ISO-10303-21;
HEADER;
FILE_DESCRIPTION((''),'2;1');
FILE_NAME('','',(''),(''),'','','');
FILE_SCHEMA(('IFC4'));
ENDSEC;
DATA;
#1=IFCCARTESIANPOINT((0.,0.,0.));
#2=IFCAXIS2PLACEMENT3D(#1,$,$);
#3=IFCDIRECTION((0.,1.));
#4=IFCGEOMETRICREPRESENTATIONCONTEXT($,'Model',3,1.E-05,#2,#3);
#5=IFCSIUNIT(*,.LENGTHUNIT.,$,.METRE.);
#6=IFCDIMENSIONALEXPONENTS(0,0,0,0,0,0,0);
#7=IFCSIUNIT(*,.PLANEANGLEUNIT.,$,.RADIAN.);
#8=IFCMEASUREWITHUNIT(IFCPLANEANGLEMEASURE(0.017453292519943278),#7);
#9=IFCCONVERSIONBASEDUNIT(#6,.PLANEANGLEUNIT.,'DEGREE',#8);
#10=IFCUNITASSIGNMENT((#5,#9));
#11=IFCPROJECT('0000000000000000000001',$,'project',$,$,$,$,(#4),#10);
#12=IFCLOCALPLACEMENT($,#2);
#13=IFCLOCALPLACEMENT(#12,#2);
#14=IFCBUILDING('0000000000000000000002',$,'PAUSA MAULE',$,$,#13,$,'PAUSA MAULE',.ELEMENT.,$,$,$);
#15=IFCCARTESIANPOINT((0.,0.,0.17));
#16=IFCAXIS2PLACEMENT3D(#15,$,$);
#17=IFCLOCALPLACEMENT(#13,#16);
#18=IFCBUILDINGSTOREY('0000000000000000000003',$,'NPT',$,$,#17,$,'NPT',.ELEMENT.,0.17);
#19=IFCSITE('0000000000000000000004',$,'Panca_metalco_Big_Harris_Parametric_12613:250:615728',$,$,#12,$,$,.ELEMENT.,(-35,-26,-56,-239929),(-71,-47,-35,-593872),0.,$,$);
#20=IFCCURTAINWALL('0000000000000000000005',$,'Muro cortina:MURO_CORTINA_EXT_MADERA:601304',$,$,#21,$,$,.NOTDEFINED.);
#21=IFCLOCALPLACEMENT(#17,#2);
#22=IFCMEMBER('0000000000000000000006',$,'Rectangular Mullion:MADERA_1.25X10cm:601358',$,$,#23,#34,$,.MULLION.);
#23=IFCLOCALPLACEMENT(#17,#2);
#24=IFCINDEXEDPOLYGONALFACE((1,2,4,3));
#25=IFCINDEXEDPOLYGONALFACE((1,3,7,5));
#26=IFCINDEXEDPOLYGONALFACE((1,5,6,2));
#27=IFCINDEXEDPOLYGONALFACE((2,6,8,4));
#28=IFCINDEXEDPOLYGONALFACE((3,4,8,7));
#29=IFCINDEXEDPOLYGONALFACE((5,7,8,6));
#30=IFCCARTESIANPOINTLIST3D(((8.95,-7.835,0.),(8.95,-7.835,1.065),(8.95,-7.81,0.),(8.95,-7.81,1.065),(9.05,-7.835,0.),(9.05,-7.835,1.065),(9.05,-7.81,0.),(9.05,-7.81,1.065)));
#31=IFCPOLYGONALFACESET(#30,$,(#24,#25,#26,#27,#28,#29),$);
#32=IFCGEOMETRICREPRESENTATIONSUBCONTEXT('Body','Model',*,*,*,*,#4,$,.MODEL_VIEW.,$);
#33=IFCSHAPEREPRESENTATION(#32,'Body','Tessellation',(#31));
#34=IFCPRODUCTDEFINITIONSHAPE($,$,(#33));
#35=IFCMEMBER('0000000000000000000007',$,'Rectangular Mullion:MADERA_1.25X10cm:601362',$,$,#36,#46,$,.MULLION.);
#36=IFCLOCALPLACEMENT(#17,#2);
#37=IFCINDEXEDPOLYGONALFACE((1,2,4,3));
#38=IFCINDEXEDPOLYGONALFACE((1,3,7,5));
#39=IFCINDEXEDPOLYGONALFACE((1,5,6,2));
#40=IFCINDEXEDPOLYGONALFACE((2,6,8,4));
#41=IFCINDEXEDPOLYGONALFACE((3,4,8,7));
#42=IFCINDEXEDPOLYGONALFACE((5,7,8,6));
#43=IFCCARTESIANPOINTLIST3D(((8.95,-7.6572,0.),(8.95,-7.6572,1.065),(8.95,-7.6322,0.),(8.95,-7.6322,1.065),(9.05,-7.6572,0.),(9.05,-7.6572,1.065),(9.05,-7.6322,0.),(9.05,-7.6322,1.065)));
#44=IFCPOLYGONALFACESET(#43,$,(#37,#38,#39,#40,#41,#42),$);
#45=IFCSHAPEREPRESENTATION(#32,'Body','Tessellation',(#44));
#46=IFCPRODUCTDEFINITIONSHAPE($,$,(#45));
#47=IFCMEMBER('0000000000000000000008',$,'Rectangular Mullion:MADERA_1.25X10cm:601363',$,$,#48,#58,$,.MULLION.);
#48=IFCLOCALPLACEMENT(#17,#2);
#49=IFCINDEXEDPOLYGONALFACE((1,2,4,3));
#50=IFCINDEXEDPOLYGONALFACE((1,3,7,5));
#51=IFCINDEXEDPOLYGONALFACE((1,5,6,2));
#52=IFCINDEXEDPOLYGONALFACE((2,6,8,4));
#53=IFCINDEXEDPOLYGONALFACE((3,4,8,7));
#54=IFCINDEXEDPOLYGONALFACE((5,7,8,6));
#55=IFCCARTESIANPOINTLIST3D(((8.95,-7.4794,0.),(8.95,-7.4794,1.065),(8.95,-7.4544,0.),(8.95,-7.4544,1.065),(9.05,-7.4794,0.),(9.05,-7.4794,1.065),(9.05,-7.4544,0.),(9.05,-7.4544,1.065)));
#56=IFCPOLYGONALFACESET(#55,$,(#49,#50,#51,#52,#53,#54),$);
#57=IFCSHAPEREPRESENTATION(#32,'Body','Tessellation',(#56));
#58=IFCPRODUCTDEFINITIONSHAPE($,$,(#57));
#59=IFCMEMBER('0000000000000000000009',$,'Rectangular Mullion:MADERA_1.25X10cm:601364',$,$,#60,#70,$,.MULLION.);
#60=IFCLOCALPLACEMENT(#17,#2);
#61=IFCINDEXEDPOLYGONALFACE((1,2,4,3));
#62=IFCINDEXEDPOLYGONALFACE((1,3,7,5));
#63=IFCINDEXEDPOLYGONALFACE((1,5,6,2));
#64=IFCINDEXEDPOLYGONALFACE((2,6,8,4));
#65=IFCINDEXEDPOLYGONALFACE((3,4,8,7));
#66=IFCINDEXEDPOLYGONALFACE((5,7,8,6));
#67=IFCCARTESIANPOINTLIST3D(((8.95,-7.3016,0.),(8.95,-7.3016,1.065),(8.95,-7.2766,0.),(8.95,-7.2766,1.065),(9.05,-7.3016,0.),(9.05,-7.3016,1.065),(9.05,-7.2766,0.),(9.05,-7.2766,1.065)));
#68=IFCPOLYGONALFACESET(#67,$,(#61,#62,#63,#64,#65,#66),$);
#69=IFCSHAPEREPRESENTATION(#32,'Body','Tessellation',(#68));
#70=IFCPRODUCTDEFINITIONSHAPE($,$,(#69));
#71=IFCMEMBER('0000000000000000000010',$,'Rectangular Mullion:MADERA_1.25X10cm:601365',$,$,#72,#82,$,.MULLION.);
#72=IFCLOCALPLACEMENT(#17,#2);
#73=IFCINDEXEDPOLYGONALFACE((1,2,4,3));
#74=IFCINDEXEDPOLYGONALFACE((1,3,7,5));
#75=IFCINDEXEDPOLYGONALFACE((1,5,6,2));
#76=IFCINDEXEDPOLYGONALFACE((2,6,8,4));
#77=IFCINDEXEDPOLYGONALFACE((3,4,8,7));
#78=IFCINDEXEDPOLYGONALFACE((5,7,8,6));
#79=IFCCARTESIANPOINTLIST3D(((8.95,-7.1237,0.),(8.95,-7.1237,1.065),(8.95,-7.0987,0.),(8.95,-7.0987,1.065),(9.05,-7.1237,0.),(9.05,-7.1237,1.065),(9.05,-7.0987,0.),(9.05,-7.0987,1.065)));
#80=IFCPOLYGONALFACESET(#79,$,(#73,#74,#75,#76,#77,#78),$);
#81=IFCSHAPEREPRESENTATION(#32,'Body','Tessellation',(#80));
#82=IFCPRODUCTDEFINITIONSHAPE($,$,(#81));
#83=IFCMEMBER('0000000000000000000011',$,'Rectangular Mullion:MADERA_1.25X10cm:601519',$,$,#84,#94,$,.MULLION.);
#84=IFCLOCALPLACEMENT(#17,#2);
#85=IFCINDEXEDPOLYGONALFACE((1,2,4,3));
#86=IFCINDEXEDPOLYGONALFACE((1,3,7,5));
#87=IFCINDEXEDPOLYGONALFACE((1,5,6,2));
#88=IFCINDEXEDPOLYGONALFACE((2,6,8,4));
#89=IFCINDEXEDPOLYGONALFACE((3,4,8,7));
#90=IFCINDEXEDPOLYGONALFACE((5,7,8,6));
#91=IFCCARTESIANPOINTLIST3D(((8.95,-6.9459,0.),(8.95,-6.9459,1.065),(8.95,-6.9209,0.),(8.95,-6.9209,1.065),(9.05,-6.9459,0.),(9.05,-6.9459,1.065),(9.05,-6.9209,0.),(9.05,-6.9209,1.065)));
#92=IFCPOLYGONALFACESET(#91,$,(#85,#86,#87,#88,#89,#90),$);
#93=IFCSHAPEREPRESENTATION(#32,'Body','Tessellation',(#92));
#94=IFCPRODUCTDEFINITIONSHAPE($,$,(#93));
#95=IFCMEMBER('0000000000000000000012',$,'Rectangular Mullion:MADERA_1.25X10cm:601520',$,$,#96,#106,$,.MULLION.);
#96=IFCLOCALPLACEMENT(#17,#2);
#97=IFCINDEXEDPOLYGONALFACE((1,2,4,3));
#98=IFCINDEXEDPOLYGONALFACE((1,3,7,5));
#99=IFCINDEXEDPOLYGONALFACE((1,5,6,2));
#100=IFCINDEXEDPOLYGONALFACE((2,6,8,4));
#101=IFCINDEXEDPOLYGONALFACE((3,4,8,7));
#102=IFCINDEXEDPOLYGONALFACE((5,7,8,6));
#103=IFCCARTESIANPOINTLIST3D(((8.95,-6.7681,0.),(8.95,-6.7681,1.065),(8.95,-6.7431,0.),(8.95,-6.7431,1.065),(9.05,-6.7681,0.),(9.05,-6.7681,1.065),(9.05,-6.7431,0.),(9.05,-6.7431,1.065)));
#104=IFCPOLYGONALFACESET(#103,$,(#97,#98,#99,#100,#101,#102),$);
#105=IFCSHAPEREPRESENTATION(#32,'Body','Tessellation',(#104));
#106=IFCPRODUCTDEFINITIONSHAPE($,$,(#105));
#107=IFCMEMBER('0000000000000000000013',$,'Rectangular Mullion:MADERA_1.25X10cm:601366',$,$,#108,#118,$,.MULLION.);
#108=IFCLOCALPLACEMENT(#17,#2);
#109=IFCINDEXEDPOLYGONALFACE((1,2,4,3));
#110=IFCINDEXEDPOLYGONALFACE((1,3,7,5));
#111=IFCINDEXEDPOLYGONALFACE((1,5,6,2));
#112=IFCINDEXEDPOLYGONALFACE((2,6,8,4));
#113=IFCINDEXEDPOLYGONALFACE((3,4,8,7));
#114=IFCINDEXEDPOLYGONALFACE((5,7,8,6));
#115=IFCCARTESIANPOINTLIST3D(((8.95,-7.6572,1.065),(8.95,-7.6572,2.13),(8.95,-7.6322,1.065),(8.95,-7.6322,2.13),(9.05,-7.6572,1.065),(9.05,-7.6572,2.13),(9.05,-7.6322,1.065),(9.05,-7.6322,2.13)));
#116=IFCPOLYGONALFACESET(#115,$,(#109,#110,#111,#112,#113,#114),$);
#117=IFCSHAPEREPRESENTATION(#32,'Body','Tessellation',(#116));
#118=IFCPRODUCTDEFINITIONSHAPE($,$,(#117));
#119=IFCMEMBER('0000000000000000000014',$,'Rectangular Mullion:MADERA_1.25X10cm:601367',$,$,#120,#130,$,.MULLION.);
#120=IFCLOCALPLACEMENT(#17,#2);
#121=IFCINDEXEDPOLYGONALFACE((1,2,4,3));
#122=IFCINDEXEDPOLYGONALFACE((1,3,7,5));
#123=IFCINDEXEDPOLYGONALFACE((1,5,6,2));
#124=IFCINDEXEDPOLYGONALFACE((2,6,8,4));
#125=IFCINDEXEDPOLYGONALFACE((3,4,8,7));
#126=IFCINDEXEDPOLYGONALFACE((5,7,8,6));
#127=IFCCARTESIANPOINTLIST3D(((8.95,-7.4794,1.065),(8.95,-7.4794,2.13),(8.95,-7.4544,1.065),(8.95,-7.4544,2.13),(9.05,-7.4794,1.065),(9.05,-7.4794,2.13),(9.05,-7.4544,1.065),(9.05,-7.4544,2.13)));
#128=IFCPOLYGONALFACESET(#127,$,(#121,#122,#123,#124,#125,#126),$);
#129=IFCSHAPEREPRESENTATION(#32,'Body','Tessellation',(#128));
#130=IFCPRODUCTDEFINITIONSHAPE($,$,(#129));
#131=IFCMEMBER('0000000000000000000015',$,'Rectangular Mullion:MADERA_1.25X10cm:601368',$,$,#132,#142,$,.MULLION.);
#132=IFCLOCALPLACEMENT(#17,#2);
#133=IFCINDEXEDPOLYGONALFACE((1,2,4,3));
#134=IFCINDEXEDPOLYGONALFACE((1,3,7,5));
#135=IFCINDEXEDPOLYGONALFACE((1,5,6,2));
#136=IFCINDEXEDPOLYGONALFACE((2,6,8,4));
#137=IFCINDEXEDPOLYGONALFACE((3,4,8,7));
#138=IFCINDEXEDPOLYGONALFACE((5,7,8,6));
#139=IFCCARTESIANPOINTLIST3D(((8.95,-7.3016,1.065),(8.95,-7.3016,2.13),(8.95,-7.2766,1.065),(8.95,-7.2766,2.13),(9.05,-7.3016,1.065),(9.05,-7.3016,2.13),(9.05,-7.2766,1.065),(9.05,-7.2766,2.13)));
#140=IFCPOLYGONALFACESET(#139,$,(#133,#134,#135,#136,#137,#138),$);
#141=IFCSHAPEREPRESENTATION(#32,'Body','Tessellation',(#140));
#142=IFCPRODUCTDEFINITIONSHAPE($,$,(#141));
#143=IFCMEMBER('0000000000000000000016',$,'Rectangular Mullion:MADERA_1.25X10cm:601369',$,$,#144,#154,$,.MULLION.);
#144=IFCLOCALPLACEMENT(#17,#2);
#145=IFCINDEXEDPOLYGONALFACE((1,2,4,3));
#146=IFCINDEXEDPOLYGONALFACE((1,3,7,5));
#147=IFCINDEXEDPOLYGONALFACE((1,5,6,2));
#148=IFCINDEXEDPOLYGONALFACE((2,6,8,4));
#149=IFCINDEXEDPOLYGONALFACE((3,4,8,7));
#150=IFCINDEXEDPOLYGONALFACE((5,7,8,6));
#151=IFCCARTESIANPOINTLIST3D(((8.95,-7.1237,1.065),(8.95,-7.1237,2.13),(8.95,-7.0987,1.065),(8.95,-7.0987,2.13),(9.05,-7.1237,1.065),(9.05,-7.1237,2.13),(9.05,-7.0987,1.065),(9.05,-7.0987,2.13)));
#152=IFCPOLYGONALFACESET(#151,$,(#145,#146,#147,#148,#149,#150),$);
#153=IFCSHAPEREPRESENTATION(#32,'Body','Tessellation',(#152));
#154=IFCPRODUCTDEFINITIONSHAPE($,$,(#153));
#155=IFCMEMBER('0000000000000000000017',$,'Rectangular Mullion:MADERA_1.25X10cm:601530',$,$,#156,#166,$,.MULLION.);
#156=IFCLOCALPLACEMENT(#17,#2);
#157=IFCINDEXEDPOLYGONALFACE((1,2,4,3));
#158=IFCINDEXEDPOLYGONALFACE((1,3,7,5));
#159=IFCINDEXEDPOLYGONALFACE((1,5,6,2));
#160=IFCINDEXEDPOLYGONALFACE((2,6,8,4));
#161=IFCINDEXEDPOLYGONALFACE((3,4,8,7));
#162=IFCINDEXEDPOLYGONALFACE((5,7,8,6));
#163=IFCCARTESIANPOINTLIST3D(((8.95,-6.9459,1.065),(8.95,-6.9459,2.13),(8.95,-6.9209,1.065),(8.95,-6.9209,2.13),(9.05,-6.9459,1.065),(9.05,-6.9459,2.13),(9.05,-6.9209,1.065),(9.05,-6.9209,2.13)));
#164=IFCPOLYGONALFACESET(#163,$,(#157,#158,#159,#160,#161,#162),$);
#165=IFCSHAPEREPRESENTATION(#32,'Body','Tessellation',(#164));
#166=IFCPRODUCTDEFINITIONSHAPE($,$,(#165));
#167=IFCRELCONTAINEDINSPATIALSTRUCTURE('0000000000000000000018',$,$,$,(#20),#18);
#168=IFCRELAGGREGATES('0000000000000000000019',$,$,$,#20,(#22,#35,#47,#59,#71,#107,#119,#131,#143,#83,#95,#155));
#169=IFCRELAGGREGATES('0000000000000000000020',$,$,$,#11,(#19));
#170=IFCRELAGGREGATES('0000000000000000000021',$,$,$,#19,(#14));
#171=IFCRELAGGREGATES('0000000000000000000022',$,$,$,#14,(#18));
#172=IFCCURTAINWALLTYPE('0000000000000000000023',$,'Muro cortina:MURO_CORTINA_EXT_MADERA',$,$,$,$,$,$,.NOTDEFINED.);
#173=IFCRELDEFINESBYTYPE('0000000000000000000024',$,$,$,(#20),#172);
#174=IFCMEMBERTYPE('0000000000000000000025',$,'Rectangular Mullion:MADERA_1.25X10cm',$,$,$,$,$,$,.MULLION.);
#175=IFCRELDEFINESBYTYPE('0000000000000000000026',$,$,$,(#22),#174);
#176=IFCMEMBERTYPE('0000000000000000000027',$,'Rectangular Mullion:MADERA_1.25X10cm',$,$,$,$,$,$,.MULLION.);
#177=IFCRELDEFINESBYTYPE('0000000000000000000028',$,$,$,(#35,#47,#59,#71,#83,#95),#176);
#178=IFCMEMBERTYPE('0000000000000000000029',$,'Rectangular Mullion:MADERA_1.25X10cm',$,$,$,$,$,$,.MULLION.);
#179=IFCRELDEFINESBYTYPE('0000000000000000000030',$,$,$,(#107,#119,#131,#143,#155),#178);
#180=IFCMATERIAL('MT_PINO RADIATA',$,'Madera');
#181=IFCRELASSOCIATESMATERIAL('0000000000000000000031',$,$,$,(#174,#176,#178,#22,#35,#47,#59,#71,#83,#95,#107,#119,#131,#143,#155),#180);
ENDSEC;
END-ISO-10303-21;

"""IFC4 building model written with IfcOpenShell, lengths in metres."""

from ifc_helpers import new_model, entity, si_unit, converted_unit, direction, frame, frame_2d, origin, place, context, subcontext, project, spatial, rectangle, extrude, source, transform, mapped, material, material_profile, profile_set, profile_usage, type_object, type_shapes, element, aggregate, save


model = new_model("IFC4")

# Units and contexts
model_context = context("Model", 3, precision=1e-05, world=origin(), true_north=direction((0.0, 1.0)))
body_context = subcontext(model_context, "Body", "Model", "MODEL_VIEW")
ifc_project = project(units=[si_unit("LENGTHUNIT", "METRE"), converted_unit("PLANEANGLEUNIT", "DEGREE", entity("IfcPlaneAngleMeasure", 0.017453292519943278), si_unit("PLANEANGLEUNIT", "RADIAN"), dimensions=[0, 0, 0, 0, 0, 0, 0])], contexts=[model_context])

# Site, building, storey
site_placement = place(None, origin())
site = spatial("IfcSite", under=ifc_project, at=site_placement, Name="Panca_metalco_Big_Harris_Parametric_12613:250:615728", CompositionType="ELEMENT", RefLatitude=(-35, -26, -56, -239929), RefLongitude=(-71, -47, -35, -593872), RefElevation=0.0)
building_placement = place(site_placement, origin())
building = spatial("IfcBuilding", under=site, at=building_placement, Name="PAUSA MAULE", LongName="PAUSA MAULE", CompositionType="ELEMENT")
storey_placement = place(building_placement, frame((0.0, 0.0, 0.17)))
storey = spatial("IfcBuildingStorey", under=building, at=storey_placement, Name="NPT", LongName="NPT", CompositionType="ELEMENT", Elevation=0.17)

# Curtain wall, members
curtain_wall_type = type_object("IfcCurtainWallType", Name="Muro cortina:MURO_CORTINA_EXT_MADERA", PredefinedType="NOTDEFINED")
curtain_wall_placement = place(storey_placement, frame((0.0, 0.0, -0.17)))
curtain_wall = element("IfcCurtainWall", 1, at=curtain_wall_placement, inside=storey, type_object=curtain_wall_type, Name="Muro cortina:MURO_CORTINA_EXT_MADERA:601304", PredefinedType="NOTDEFINED")
ifc_material = material(Name="MT_PINO RADIATA", Category="Madera")
ifc_material_profile = material_profile(ifc_material, rectangle(XDim=0.025, YDim=0.1, at=frame_2d((0.0, 0.0), x_axis=(1.0, 0.0))), Name="MADERA_1.25X10cm")
ifc_profile_set = profile_set([ifc_material_profile], Name="MADERA_1.25X10cm")
ifc_profile_usage = profile_usage(ifc_profile_set)
member_type_1 = type_object("IfcMemberType", Name="Rectangular Mullion:MADERA_1.25X10cm", PredefinedType="MULLION", material=ifc_profile_set)
shared_shape_1 = source(origin(), body_context, "Body", "SweptSolid", [
    extrude(rectangle(XDim=0.025, YDim=0.1, at=frame_2d((0.0, 0.0), x_axis=(1.0, 0.0))), frame((-0.0125, 0.0, -1.065), z_axis=(0.0, 0.0, 1.0), x_axis=(-1.0, 0.0, 0.0)), (0.0, 0.0, 1.0), 1.065),
])
type_shapes(member_type_1, [shared_shape_1])
member_1_placement = place(curtain_wall_placement, frame((9.0, -7.835, 1.235), z_axis=(0.0, 0.0, 1.0), x_axis=(0.0, -1.0, 0.0)))
member_1 = element("IfcMember", 2, at=member_1_placement, type_object=member_type_1, material=ifc_profile_usage, Name="Rectangular Mullion:MADERA_1.25X10cm:601358", PredefinedType="MULLION", context=body_context, shape_type="MappedRepresentation", body=[
    mapped(shared_shape_1, transform((0.0, 0.0, 0.0), scale=1.0)),
])
member_type_2 = type_object("IfcMemberType", Name="Rectangular Mullion:MADERA_1.25X10cm", PredefinedType="MULLION", material=ifc_profile_set)
shared_shape_2 = source(origin(), body_context, "Body", "SweptSolid", [
    extrude(rectangle(XDim=0.025, YDim=0.1, at=frame_2d((0.0, 0.0), x_axis=(1.0, 0.0))), frame((0.0, 0.0, -1.065), z_axis=(0.0, 0.0, 1.0), x_axis=(-1.0, 0.0, 0.0)), (0.0, 0.0, 1.0), 1.065),
])
type_shapes(member_type_2, [shared_shape_2])
member_2_placement = place(curtain_wall_placement, frame((9.0, -7.6447, 0.17), z_axis=(0.0, 0.0, -1.0), x_axis=(0.0, 1.0, 0.0)))
member_2 = element("IfcMember", 3, at=member_2_placement, type_object=member_type_2, material=ifc_profile_usage, Name="Rectangular Mullion:MADERA_1.25X10cm:601362", PredefinedType="MULLION", context=body_context, shape_type="MappedRepresentation", body=[
    mapped(shared_shape_2, transform((0.0, 0.0, 0.0), scale=1.0)),
])
member_3_placement = place(curtain_wall_placement, frame((9.0, -7.4669, 0.17), z_axis=(0.0, 0.0, -1.0), x_axis=(0.0, 1.0, 0.0)))
member_3 = element("IfcMember", 4, at=member_3_placement, type_object=member_type_2, material=ifc_profile_usage, Name="Rectangular Mullion:MADERA_1.25X10cm:601363", PredefinedType="MULLION", context=body_context, shape_type="MappedRepresentation", body=[
    mapped(shared_shape_2, transform((0.0, 0.0, 0.0), scale=1.0)),
])
member_4_placement = place(curtain_wall_placement, frame((9.0, -7.2891, 0.17), z_axis=(0.0, 0.0, -1.0), x_axis=(0.0, 1.0, 0.0)))
member_4 = element("IfcMember", 5, at=member_4_placement, type_object=member_type_2, material=ifc_profile_usage, Name="Rectangular Mullion:MADERA_1.25X10cm:601364", PredefinedType="MULLION", context=body_context, shape_type="MappedRepresentation", body=[
    mapped(shared_shape_2, transform((0.0, 0.0, 0.0), scale=1.0)),
])
member_5_placement = place(curtain_wall_placement, frame((9.0, -7.1112, 0.17), z_axis=(0.0, 0.0, -1.0), x_axis=(0.0, 1.0, 0.0)))
member_5 = element("IfcMember", 6, at=member_5_placement, type_object=member_type_2, material=ifc_profile_usage, Name="Rectangular Mullion:MADERA_1.25X10cm:601365", PredefinedType="MULLION", context=body_context, shape_type="MappedRepresentation", body=[
    mapped(shared_shape_2, transform((0.0, 0.0, 0.0), scale=1.0)),
])
member_6_placement = place(curtain_wall_placement, frame((9.0, -6.9334, 0.17), z_axis=(0.0, 0.0, -1.0), x_axis=(0.0, 1.0, 0.0)))
member_6 = element("IfcMember", 7, at=member_6_placement, type_object=member_type_2, material=ifc_profile_usage, Name="Rectangular Mullion:MADERA_1.25X10cm:601519", PredefinedType="MULLION", context=body_context, shape_type="MappedRepresentation", body=[
    mapped(shared_shape_2, transform((0.0, 0.0, 0.0), scale=1.0)),
])
member_7_placement = place(curtain_wall_placement, frame((9.0, -6.7556, 0.17), z_axis=(0.0, 0.0, -1.0), x_axis=(0.0, 1.0, 0.0)))
member_7 = element("IfcMember", 8, at=member_7_placement, type_object=member_type_2, material=ifc_profile_usage, Name="Rectangular Mullion:MADERA_1.25X10cm:601520", PredefinedType="MULLION", context=body_context, shape_type="MappedRepresentation", body=[
    mapped(shared_shape_2, transform((0.0, 0.0, 0.0), scale=1.0)),
])
member_type_3 = type_object("IfcMemberType", Name="Rectangular Mullion:MADERA_1.25X10cm", PredefinedType="MULLION", material=ifc_profile_set)
shared_shape_3 = source(origin(), body_context, "Body", "SweptSolid", [
    extrude(rectangle(XDim=0.025, YDim=0.1, at=frame_2d((0.0, 0.0), x_axis=(1.0, 0.0))), frame((0.0, 0.0, -1.065), z_axis=(0.0, 0.0, 1.0), x_axis=(-1.0, 0.0, 0.0)), (0.0, 0.0, 1.0), 1.065),
])
type_shapes(member_type_3, [shared_shape_3])
member_8_placement = place(curtain_wall_placement, frame((9.0, -7.6447, 1.235), z_axis=(0.0, 0.0, -1.0), x_axis=(0.0, 1.0, 0.0)))
member_8 = element("IfcMember", 9, at=member_8_placement, type_object=member_type_3, material=ifc_profile_usage, Name="Rectangular Mullion:MADERA_1.25X10cm:601366", PredefinedType="MULLION", context=body_context, shape_type="MappedRepresentation", body=[
    mapped(shared_shape_3, transform((0.0, 0.0, 0.0), scale=1.0)),
])
member_9_placement = place(curtain_wall_placement, frame((9.0, -7.4669, 1.235), z_axis=(0.0, 0.0, -1.0), x_axis=(0.0, 1.0, 0.0)))
member_9 = element("IfcMember", 10, at=member_9_placement, type_object=member_type_3, material=ifc_profile_usage, Name="Rectangular Mullion:MADERA_1.25X10cm:601367", PredefinedType="MULLION", context=body_context, shape_type="MappedRepresentation", body=[
    mapped(shared_shape_3, transform((0.0, 0.0, 0.0), scale=1.0)),
])
member_10_placement = place(curtain_wall_placement, frame((9.0, -7.2891, 1.235), z_axis=(0.0, 0.0, -1.0), x_axis=(0.0, 1.0, 0.0)))
member_10 = element("IfcMember", 11, at=member_10_placement, type_object=member_type_3, material=ifc_profile_usage, Name="Rectangular Mullion:MADERA_1.25X10cm:601368", PredefinedType="MULLION", context=body_context, shape_type="MappedRepresentation", body=[
    mapped(shared_shape_3, transform((0.0, 0.0, 0.0), scale=1.0)),
])
member_11_placement = place(curtain_wall_placement, frame((9.0, -7.1112, 1.235), z_axis=(0.0, 0.0, -1.0), x_axis=(0.0, 1.0, 0.0)))
member_11 = element("IfcMember", 12, at=member_11_placement, type_object=member_type_3, material=ifc_profile_usage, Name="Rectangular Mullion:MADERA_1.25X10cm:601369", PredefinedType="MULLION", context=body_context, shape_type="MappedRepresentation", body=[
    mapped(shared_shape_3, transform((0.0, 0.0, 0.0), scale=1.0)),
])
member_12_placement = place(curtain_wall_placement, frame((9.0, -6.9334, 1.235), z_axis=(0.0, 0.0, -1.0), x_axis=(0.0, 1.0, 0.0)))
member_12 = element("IfcMember", 13, at=member_12_placement, type_object=member_type_3, material=ifc_profile_usage, Name="Rectangular Mullion:MADERA_1.25X10cm:601530", PredefinedType="MULLION", context=body_context, shape_type="MappedRepresentation", body=[
    mapped(shared_shape_3, transform((0.0, 0.0, 0.0), scale=1.0)),
])
aggregate(curtain_wall, [member_1, member_2, member_3, member_4, member_5, member_8, member_9, member_10, member_11, member_6, member_7, member_12])

save(model, "model.ifc")
